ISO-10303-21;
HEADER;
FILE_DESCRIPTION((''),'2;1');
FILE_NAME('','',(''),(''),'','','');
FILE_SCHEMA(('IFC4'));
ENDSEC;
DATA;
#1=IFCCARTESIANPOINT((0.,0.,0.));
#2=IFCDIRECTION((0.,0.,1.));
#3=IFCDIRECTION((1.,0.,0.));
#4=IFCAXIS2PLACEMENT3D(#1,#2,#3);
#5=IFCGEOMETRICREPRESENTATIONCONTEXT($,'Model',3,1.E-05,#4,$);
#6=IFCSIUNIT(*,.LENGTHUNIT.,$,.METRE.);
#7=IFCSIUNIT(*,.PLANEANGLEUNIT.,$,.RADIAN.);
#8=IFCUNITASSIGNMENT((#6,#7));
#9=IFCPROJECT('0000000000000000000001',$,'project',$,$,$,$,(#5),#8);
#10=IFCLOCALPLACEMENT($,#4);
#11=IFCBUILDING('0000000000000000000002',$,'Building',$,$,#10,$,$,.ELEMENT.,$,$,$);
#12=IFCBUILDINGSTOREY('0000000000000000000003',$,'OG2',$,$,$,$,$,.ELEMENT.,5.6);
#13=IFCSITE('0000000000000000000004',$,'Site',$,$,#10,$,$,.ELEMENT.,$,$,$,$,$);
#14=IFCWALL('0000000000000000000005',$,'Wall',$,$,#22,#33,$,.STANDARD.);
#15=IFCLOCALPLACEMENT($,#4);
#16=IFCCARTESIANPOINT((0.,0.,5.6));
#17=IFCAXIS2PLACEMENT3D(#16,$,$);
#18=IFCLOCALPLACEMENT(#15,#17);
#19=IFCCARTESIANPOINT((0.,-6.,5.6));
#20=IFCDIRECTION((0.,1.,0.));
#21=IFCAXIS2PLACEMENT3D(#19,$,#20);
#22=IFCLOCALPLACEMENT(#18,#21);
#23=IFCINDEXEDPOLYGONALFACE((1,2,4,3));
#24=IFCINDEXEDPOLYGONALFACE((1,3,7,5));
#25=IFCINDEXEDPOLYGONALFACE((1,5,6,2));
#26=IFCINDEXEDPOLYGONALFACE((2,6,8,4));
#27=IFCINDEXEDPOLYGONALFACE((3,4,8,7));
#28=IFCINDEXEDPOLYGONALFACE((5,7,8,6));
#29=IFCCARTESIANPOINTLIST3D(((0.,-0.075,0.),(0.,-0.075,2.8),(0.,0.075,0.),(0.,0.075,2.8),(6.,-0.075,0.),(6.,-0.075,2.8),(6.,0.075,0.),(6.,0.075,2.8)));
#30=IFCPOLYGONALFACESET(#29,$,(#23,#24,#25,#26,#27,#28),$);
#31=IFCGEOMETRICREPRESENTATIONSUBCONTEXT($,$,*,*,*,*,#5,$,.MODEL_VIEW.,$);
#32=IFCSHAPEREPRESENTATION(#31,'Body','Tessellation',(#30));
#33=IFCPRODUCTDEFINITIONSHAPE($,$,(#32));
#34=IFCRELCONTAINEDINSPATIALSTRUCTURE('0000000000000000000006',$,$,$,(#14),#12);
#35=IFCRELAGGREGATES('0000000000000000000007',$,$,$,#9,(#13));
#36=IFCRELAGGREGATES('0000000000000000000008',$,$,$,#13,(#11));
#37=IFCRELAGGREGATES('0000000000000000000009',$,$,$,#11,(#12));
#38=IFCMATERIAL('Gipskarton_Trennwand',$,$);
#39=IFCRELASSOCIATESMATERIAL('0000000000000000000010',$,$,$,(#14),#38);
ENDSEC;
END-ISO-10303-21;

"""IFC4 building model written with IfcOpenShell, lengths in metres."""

from ifc_helpers import new_model, si_unit, frame, frame_2d, origin, origin_with_axes, place, context, subcontext, project, spatial, rectangle, extrude, material, element, save


model = new_model("IFC4")

# Units and contexts
model_context = context("Model", 3, precision=1e-05, world=origin_with_axes())
sub_context = subcontext(model_context, None, None, "MODEL_VIEW")
ifc_project = project(units=[si_unit("LENGTHUNIT", "METRE"), si_unit("PLANEANGLEUNIT", "RADIAN")], contexts=[model_context])

# Site, building, storey
placement_1 = place(None, origin_with_axes())
site = spatial("IfcSite", under=ifc_project, at=placement_1, Name="Site", CompositionType="ELEMENT")
building = spatial("IfcBuilding", under=site, at=placement_1, Name="Building", CompositionType="ELEMENT")
storey = spatial("IfcBuildingStorey", under=building, Name="OG2", CompositionType="ELEMENT", Elevation=5.6)

# Wall
ifc_material = material(Name="Gipskarton_Trennwand")
placement_2 = place(None, origin_with_axes())
placement_3 = place(placement_2, frame((0.0, 0.0, 5.6)))
wall_placement = place(placement_3, frame((0.0, -6.0, 5.6), x_axis=(0.0, 1.0, 0.0)))
element("IfcWall", 1, at=wall_placement, inside=storey, material=ifc_material, Name="Wall", PredefinedType="STANDARD", context=sub_context, shape_type="SweptSolid", body=[
    extrude(rectangle(XDim=6.0, YDim=0.15, at=frame_2d((3.0, 0.0))), origin(), (0.0, 0.0, 1.0), 2.8),
])

save(model, "model.ifc")
